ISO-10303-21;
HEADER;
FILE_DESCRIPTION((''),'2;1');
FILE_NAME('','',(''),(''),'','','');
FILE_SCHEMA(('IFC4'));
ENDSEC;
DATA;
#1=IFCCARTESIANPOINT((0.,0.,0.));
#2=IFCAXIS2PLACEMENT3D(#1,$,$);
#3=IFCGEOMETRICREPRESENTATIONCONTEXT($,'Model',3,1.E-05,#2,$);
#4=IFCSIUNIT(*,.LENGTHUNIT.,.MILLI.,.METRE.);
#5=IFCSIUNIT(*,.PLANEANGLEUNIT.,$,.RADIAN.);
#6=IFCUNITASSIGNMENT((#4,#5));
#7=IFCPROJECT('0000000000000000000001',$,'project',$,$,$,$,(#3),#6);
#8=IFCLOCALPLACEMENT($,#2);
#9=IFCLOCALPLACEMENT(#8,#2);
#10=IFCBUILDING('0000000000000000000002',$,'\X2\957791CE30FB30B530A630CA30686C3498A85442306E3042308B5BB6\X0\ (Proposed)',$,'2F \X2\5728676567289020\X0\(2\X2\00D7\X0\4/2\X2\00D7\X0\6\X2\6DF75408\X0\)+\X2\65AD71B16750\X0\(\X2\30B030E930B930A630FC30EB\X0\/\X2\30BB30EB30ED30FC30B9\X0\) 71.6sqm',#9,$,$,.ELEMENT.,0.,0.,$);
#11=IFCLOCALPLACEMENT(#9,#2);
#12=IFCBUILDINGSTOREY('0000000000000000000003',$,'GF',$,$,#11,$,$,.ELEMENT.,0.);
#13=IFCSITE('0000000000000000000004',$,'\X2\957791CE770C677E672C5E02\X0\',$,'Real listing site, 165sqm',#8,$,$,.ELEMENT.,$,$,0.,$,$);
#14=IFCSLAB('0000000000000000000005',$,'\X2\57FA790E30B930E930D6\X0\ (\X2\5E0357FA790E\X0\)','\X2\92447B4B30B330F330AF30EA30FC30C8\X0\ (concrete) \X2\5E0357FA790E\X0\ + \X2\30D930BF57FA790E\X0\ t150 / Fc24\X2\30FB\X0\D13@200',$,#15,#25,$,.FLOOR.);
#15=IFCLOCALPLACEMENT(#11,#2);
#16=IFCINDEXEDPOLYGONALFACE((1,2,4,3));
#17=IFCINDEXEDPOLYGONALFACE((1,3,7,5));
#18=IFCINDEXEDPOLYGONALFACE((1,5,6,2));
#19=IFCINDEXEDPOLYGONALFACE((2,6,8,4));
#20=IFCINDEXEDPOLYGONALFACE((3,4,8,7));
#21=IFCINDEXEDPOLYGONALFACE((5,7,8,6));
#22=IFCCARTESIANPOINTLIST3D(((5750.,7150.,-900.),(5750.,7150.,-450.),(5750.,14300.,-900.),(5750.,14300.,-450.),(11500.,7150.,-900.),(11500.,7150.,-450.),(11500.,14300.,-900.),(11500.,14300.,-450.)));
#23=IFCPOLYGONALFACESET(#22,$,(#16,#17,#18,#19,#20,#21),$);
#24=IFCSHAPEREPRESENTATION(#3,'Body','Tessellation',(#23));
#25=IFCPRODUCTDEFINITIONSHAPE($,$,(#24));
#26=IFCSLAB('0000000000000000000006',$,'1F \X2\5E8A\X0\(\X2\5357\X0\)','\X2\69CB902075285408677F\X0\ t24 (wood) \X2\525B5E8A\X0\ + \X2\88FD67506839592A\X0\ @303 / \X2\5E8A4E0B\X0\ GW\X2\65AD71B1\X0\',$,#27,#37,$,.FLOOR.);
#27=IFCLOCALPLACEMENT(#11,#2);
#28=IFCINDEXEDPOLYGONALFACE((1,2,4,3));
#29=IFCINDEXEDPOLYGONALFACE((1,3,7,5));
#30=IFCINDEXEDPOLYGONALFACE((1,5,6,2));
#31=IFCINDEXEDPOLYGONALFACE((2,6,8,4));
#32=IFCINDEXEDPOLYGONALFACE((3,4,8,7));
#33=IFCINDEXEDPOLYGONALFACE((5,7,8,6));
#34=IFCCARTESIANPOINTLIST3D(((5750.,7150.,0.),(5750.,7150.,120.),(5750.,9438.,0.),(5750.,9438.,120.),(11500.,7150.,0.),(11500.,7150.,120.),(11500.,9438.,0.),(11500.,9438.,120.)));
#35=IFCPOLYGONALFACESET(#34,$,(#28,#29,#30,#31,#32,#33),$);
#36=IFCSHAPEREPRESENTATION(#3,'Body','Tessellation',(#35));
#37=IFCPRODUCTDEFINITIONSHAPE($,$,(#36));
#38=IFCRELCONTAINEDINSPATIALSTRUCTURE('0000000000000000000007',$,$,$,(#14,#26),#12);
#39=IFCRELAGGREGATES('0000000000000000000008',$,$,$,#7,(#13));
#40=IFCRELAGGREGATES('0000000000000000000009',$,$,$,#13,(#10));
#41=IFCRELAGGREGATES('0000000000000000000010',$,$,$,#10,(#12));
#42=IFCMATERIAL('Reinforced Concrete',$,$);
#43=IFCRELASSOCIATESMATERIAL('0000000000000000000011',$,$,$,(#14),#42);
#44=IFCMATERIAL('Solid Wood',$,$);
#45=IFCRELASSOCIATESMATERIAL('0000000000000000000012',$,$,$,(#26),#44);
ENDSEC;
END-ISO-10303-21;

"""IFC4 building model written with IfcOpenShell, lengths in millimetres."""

from ifc_helpers import new_model, si_unit, frame, frame_2d, origin, place, context, project, spatial, rectangle, extrude, material, element, save


model = new_model("IFC4")

# Units and contexts
model_context = context("Model", 3, precision=1e-05, world=origin())
ifc_project = project(units=[si_unit("LENGTHUNIT", "METRE", prefix="MILLI"), si_unit("PLANEANGLEUNIT", "RADIAN")], contexts=[model_context])

# Site, building, storey
site_placement = place(None, origin())
site = spatial("IfcSite", under=ifc_project, at=site_placement, Name="長野県松本市", ObjectType="Real listing site, 165sqm", CompositionType="ELEMENT", RefElevation=0.0)
building_placement = place(site_placement, origin())
building = spatial("IfcBuilding", under=site, at=building_placement, Name="長野・サウナと水風呂のある家 (Proposed)", ObjectType="2F 在来木造(2×4/2×6混合)+断熱材(グラスウール/セルロース) 71.6sqm", CompositionType="ELEMENT", ElevationOfRefHeight=0.0, ElevationOfTerrain=0.0)
storey_placement = place(building_placement, origin())
storey = spatial("IfcBuildingStorey", under=building, at=storey_placement, Name="GF", CompositionType="ELEMENT", Elevation=0.0)

# Shared definitions
ifc_material_1 = material(Name="Solid Wood")

# Slabs
ifc_material_2 = material(Name="Reinforced Concrete")
slab_1_placement = place(storey_placement, frame((2875.0, 3575.0, -450.0)))
element("IfcSlab", 1, at=slab_1_placement, inside=storey, material=ifc_material_2, Name="基礎スラブ (布基礎)", Description="鉄筋コンクリート (concrete) 布基礎 + ベタ基礎 t150 / Fc24・D13@200", PredefinedType="FLOOR", context=model_context, shape_type="SweptSolid", body=[
    extrude(rectangle(XDim=5750.0, YDim=7150.0, at=frame_2d((2875.0, 3575.0))), frame((2875.0, 3575.0, -450.0)), (0.0, 0.0, 1.0), 450.0),
])
slab_2_placement = place(storey_placement, frame((2875.0, 3575.0, 0.0)))
element("IfcSlab", 2, at=slab_2_placement, inside=storey, material=ifc_material_1, Name="1F 床(南)", Description="構造用合板 t24 (wood) 剛床 + 製材根太 @303 / 床下 GW断熱", PredefinedType="FLOOR", context=model_context, shape_type="SweptSolid", body=[
    extrude(rectangle(XDim=5750.0, YDim=2288.0, at=frame_2d((2875.0, 1144.0))), frame((2875.0, 3575.0, 0.0)), (0.0, 0.0, 1.0), 120.0),
])

save(model, "model.ifc")
